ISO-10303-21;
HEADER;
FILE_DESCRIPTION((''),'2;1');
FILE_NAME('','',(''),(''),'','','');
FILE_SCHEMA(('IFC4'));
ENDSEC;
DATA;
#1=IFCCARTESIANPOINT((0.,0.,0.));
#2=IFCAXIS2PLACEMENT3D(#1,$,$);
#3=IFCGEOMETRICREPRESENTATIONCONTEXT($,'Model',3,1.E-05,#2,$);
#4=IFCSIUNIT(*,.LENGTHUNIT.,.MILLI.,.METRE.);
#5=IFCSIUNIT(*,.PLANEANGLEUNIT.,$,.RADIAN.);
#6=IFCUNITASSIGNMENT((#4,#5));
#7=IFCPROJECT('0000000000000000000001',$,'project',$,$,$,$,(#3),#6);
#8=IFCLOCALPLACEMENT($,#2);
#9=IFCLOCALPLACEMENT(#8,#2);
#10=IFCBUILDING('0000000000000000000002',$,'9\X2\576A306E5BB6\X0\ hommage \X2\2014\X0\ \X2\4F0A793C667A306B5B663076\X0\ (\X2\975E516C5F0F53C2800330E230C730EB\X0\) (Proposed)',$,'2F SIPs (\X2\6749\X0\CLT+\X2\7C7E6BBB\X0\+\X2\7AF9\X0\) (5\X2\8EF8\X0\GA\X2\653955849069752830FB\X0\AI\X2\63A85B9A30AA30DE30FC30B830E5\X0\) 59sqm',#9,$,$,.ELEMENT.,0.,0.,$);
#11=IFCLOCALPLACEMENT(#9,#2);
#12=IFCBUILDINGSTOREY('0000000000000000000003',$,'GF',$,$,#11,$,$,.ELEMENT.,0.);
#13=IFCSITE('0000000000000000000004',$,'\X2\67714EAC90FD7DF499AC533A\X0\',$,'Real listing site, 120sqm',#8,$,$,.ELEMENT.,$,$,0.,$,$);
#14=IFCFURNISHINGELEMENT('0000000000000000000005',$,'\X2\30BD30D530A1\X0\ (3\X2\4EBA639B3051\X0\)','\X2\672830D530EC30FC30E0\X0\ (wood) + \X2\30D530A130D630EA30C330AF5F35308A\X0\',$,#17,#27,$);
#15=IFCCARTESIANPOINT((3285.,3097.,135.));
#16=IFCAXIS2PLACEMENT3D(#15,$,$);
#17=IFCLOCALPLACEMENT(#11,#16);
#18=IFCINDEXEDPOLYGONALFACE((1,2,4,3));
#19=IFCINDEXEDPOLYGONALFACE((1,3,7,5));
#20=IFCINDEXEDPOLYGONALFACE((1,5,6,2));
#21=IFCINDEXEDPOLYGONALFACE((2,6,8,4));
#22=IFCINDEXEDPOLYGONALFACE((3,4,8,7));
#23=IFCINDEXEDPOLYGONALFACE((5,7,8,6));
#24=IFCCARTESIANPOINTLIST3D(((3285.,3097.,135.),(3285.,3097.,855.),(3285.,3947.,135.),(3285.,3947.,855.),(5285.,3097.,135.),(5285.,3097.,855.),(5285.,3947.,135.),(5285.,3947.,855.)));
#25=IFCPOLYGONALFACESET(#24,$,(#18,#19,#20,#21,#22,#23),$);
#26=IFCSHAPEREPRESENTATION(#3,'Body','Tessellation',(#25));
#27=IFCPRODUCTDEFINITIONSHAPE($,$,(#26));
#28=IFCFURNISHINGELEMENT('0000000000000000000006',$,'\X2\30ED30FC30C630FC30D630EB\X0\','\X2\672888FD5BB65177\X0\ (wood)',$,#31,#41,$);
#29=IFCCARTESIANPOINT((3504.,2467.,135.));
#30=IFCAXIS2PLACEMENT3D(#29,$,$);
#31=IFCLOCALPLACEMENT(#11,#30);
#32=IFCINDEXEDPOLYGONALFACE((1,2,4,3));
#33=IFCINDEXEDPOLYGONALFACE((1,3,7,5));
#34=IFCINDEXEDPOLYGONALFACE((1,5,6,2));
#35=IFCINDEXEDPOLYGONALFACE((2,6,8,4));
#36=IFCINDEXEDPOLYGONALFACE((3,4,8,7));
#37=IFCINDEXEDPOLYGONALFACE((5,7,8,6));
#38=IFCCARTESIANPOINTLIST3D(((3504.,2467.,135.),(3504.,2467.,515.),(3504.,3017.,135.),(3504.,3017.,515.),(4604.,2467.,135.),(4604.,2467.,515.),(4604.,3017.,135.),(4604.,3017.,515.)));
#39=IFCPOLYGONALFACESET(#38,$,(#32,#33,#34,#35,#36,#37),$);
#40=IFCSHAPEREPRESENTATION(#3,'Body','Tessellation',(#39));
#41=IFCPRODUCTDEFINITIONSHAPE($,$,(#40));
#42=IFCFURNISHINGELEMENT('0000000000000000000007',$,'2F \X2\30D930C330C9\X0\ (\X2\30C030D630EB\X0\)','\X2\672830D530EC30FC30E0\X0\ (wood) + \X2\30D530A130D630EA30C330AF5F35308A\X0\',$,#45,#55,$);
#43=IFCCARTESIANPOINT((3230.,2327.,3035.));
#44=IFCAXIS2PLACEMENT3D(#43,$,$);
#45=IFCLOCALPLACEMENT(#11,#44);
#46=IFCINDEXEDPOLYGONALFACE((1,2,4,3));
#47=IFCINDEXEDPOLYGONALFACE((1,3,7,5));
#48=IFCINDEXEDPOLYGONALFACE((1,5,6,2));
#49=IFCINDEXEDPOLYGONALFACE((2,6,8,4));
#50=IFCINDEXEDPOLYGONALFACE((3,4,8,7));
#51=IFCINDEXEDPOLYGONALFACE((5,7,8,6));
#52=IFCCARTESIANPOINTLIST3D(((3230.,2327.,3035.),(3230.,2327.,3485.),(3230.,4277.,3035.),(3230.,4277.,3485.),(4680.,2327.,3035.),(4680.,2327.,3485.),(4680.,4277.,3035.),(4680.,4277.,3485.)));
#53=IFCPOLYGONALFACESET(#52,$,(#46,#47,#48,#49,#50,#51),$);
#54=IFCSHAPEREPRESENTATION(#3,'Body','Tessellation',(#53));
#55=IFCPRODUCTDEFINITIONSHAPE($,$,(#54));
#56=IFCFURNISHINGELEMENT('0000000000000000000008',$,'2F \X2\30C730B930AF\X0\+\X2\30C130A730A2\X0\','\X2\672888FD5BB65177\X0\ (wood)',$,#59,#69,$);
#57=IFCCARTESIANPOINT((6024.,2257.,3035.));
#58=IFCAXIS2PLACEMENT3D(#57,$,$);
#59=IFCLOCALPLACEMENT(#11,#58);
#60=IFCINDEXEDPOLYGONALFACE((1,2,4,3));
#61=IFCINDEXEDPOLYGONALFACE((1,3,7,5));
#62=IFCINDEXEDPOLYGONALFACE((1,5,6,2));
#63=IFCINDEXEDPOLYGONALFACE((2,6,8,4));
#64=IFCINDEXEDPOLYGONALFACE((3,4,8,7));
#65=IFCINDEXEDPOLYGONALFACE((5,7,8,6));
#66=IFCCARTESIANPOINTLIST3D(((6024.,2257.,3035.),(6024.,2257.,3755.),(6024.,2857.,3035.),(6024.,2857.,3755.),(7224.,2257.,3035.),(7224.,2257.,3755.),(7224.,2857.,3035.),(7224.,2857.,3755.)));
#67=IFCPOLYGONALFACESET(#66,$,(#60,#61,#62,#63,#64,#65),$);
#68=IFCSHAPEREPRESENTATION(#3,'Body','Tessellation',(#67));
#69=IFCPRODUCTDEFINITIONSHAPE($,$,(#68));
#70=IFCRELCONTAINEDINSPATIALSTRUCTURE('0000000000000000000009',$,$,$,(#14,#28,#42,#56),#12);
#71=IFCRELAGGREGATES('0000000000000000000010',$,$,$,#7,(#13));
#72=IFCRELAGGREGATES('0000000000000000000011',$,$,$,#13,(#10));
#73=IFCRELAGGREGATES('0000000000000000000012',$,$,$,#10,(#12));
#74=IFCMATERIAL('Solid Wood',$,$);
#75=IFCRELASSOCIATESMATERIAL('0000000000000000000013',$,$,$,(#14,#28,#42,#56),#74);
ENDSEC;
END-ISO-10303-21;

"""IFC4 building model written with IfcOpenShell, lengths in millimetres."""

from ifc_helpers import new_model, si_unit, frame, frame_2d, origin, place, context, project, spatial, rectangle, extrude, material, element, save


model = new_model("IFC4")

# Units and contexts
model_context = context("Model", 3, precision=1e-05, world=origin())
ifc_project = project(units=[si_unit("LENGTHUNIT", "METRE", prefix="MILLI"), si_unit("PLANEANGLEUNIT", "RADIAN")], contexts=[model_context])

# Site, building, storey
site_placement = place(None, origin())
site = spatial("IfcSite", under=ifc_project, at=site_placement, Name="東京都練馬区", ObjectType="Real listing site, 120sqm", CompositionType="ELEMENT", RefElevation=0.0)
building_placement = place(site_placement, origin())
building = spatial("IfcBuilding", under=site, at=building_placement, Name="9坪の家 hommage — 伊礼智に学ぶ (非公式参考モデル) (Proposed)", ObjectType="2F SIPs (杉CLT+籾殻+竹) (5軸GA改善適用・AI推定オマージュ) 59sqm", CompositionType="ELEMENT", ElevationOfRefHeight=0.0, ElevationOfTerrain=0.0)
storey_placement = place(building_placement, origin())
storey = spatial("IfcBuildingStorey", under=building, at=storey_placement, Name="GF", CompositionType="ELEMENT", Elevation=0.0)

# Shared definitions
ifc_material_1 = material(Name="Solid Wood")

# Furnishing elements
furnishing_1_placement = place(storey_placement, frame((3285.0, 3097.0, 135.0)))
element("IfcFurnishingElement", 1, at=furnishing_1_placement, inside=storey, material=ifc_material_1, Name="ソファ (3人掛け)", Description="木フレーム (wood) + ファブリック張り", context=model_context, shape_type="SweptSolid", body=[
    extrude(rectangle(XDim=2000.0, YDim=850.0, at=frame_2d((1000.0, 425.0))), frame((3285.0, 3097.0, 135.0)), (0.0, 0.0, 1.0), 720.0),
])
furnishing_2_placement = place(storey_placement, frame((3504.0, 2467.0, 135.0)))
element("IfcFurnishingElement", 2, at=furnishing_2_placement, inside=storey, material=ifc_material_1, Name="ローテーブル", Description="木製家具 (wood)", context=model_context, shape_type="SweptSolid", body=[
    extrude(rectangle(XDim=1100.0, YDim=550.0, at=frame_2d((550.0, 275.0))), frame((3504.0, 2467.0, 135.0)), (0.0, 0.0, 1.0), 380.0),
])
furnishing_3_placement = place(storey_placement, frame((3230.0, 2327.0, 3035.0)))
element("IfcFurnishingElement", 3, at=furnishing_3_placement, inside=storey, material=ifc_material_1, Name="2F ベッド (ダブル)", Description="木フレーム (wood) + ファブリック張り", context=model_context, shape_type="SweptSolid", body=[
    extrude(rectangle(XDim=1450.0, YDim=1950.0, at=frame_2d((725.0, 975.0))), frame((3230.0, 2327.0, 3035.0)), (0.0, 0.0, 1.0), 450.0),
])
furnishing_4_placement = place(storey_placement, frame((6024.0, 2257.0, 3035.0)))
element("IfcFurnishingElement", 4, at=furnishing_4_placement, inside=storey, material=ifc_material_1, Name="2F デスク+チェア", Description="木製家具 (wood)", context=model_context, shape_type="SweptSolid", body=[
    extrude(rectangle(XDim=1200.0, YDim=600.0, at=frame_2d((600.0, 300.0))), frame((6024.0, 2257.0, 3035.0)), (0.0, 0.0, 1.0), 720.0),
])

save(model, "model.ifc")
